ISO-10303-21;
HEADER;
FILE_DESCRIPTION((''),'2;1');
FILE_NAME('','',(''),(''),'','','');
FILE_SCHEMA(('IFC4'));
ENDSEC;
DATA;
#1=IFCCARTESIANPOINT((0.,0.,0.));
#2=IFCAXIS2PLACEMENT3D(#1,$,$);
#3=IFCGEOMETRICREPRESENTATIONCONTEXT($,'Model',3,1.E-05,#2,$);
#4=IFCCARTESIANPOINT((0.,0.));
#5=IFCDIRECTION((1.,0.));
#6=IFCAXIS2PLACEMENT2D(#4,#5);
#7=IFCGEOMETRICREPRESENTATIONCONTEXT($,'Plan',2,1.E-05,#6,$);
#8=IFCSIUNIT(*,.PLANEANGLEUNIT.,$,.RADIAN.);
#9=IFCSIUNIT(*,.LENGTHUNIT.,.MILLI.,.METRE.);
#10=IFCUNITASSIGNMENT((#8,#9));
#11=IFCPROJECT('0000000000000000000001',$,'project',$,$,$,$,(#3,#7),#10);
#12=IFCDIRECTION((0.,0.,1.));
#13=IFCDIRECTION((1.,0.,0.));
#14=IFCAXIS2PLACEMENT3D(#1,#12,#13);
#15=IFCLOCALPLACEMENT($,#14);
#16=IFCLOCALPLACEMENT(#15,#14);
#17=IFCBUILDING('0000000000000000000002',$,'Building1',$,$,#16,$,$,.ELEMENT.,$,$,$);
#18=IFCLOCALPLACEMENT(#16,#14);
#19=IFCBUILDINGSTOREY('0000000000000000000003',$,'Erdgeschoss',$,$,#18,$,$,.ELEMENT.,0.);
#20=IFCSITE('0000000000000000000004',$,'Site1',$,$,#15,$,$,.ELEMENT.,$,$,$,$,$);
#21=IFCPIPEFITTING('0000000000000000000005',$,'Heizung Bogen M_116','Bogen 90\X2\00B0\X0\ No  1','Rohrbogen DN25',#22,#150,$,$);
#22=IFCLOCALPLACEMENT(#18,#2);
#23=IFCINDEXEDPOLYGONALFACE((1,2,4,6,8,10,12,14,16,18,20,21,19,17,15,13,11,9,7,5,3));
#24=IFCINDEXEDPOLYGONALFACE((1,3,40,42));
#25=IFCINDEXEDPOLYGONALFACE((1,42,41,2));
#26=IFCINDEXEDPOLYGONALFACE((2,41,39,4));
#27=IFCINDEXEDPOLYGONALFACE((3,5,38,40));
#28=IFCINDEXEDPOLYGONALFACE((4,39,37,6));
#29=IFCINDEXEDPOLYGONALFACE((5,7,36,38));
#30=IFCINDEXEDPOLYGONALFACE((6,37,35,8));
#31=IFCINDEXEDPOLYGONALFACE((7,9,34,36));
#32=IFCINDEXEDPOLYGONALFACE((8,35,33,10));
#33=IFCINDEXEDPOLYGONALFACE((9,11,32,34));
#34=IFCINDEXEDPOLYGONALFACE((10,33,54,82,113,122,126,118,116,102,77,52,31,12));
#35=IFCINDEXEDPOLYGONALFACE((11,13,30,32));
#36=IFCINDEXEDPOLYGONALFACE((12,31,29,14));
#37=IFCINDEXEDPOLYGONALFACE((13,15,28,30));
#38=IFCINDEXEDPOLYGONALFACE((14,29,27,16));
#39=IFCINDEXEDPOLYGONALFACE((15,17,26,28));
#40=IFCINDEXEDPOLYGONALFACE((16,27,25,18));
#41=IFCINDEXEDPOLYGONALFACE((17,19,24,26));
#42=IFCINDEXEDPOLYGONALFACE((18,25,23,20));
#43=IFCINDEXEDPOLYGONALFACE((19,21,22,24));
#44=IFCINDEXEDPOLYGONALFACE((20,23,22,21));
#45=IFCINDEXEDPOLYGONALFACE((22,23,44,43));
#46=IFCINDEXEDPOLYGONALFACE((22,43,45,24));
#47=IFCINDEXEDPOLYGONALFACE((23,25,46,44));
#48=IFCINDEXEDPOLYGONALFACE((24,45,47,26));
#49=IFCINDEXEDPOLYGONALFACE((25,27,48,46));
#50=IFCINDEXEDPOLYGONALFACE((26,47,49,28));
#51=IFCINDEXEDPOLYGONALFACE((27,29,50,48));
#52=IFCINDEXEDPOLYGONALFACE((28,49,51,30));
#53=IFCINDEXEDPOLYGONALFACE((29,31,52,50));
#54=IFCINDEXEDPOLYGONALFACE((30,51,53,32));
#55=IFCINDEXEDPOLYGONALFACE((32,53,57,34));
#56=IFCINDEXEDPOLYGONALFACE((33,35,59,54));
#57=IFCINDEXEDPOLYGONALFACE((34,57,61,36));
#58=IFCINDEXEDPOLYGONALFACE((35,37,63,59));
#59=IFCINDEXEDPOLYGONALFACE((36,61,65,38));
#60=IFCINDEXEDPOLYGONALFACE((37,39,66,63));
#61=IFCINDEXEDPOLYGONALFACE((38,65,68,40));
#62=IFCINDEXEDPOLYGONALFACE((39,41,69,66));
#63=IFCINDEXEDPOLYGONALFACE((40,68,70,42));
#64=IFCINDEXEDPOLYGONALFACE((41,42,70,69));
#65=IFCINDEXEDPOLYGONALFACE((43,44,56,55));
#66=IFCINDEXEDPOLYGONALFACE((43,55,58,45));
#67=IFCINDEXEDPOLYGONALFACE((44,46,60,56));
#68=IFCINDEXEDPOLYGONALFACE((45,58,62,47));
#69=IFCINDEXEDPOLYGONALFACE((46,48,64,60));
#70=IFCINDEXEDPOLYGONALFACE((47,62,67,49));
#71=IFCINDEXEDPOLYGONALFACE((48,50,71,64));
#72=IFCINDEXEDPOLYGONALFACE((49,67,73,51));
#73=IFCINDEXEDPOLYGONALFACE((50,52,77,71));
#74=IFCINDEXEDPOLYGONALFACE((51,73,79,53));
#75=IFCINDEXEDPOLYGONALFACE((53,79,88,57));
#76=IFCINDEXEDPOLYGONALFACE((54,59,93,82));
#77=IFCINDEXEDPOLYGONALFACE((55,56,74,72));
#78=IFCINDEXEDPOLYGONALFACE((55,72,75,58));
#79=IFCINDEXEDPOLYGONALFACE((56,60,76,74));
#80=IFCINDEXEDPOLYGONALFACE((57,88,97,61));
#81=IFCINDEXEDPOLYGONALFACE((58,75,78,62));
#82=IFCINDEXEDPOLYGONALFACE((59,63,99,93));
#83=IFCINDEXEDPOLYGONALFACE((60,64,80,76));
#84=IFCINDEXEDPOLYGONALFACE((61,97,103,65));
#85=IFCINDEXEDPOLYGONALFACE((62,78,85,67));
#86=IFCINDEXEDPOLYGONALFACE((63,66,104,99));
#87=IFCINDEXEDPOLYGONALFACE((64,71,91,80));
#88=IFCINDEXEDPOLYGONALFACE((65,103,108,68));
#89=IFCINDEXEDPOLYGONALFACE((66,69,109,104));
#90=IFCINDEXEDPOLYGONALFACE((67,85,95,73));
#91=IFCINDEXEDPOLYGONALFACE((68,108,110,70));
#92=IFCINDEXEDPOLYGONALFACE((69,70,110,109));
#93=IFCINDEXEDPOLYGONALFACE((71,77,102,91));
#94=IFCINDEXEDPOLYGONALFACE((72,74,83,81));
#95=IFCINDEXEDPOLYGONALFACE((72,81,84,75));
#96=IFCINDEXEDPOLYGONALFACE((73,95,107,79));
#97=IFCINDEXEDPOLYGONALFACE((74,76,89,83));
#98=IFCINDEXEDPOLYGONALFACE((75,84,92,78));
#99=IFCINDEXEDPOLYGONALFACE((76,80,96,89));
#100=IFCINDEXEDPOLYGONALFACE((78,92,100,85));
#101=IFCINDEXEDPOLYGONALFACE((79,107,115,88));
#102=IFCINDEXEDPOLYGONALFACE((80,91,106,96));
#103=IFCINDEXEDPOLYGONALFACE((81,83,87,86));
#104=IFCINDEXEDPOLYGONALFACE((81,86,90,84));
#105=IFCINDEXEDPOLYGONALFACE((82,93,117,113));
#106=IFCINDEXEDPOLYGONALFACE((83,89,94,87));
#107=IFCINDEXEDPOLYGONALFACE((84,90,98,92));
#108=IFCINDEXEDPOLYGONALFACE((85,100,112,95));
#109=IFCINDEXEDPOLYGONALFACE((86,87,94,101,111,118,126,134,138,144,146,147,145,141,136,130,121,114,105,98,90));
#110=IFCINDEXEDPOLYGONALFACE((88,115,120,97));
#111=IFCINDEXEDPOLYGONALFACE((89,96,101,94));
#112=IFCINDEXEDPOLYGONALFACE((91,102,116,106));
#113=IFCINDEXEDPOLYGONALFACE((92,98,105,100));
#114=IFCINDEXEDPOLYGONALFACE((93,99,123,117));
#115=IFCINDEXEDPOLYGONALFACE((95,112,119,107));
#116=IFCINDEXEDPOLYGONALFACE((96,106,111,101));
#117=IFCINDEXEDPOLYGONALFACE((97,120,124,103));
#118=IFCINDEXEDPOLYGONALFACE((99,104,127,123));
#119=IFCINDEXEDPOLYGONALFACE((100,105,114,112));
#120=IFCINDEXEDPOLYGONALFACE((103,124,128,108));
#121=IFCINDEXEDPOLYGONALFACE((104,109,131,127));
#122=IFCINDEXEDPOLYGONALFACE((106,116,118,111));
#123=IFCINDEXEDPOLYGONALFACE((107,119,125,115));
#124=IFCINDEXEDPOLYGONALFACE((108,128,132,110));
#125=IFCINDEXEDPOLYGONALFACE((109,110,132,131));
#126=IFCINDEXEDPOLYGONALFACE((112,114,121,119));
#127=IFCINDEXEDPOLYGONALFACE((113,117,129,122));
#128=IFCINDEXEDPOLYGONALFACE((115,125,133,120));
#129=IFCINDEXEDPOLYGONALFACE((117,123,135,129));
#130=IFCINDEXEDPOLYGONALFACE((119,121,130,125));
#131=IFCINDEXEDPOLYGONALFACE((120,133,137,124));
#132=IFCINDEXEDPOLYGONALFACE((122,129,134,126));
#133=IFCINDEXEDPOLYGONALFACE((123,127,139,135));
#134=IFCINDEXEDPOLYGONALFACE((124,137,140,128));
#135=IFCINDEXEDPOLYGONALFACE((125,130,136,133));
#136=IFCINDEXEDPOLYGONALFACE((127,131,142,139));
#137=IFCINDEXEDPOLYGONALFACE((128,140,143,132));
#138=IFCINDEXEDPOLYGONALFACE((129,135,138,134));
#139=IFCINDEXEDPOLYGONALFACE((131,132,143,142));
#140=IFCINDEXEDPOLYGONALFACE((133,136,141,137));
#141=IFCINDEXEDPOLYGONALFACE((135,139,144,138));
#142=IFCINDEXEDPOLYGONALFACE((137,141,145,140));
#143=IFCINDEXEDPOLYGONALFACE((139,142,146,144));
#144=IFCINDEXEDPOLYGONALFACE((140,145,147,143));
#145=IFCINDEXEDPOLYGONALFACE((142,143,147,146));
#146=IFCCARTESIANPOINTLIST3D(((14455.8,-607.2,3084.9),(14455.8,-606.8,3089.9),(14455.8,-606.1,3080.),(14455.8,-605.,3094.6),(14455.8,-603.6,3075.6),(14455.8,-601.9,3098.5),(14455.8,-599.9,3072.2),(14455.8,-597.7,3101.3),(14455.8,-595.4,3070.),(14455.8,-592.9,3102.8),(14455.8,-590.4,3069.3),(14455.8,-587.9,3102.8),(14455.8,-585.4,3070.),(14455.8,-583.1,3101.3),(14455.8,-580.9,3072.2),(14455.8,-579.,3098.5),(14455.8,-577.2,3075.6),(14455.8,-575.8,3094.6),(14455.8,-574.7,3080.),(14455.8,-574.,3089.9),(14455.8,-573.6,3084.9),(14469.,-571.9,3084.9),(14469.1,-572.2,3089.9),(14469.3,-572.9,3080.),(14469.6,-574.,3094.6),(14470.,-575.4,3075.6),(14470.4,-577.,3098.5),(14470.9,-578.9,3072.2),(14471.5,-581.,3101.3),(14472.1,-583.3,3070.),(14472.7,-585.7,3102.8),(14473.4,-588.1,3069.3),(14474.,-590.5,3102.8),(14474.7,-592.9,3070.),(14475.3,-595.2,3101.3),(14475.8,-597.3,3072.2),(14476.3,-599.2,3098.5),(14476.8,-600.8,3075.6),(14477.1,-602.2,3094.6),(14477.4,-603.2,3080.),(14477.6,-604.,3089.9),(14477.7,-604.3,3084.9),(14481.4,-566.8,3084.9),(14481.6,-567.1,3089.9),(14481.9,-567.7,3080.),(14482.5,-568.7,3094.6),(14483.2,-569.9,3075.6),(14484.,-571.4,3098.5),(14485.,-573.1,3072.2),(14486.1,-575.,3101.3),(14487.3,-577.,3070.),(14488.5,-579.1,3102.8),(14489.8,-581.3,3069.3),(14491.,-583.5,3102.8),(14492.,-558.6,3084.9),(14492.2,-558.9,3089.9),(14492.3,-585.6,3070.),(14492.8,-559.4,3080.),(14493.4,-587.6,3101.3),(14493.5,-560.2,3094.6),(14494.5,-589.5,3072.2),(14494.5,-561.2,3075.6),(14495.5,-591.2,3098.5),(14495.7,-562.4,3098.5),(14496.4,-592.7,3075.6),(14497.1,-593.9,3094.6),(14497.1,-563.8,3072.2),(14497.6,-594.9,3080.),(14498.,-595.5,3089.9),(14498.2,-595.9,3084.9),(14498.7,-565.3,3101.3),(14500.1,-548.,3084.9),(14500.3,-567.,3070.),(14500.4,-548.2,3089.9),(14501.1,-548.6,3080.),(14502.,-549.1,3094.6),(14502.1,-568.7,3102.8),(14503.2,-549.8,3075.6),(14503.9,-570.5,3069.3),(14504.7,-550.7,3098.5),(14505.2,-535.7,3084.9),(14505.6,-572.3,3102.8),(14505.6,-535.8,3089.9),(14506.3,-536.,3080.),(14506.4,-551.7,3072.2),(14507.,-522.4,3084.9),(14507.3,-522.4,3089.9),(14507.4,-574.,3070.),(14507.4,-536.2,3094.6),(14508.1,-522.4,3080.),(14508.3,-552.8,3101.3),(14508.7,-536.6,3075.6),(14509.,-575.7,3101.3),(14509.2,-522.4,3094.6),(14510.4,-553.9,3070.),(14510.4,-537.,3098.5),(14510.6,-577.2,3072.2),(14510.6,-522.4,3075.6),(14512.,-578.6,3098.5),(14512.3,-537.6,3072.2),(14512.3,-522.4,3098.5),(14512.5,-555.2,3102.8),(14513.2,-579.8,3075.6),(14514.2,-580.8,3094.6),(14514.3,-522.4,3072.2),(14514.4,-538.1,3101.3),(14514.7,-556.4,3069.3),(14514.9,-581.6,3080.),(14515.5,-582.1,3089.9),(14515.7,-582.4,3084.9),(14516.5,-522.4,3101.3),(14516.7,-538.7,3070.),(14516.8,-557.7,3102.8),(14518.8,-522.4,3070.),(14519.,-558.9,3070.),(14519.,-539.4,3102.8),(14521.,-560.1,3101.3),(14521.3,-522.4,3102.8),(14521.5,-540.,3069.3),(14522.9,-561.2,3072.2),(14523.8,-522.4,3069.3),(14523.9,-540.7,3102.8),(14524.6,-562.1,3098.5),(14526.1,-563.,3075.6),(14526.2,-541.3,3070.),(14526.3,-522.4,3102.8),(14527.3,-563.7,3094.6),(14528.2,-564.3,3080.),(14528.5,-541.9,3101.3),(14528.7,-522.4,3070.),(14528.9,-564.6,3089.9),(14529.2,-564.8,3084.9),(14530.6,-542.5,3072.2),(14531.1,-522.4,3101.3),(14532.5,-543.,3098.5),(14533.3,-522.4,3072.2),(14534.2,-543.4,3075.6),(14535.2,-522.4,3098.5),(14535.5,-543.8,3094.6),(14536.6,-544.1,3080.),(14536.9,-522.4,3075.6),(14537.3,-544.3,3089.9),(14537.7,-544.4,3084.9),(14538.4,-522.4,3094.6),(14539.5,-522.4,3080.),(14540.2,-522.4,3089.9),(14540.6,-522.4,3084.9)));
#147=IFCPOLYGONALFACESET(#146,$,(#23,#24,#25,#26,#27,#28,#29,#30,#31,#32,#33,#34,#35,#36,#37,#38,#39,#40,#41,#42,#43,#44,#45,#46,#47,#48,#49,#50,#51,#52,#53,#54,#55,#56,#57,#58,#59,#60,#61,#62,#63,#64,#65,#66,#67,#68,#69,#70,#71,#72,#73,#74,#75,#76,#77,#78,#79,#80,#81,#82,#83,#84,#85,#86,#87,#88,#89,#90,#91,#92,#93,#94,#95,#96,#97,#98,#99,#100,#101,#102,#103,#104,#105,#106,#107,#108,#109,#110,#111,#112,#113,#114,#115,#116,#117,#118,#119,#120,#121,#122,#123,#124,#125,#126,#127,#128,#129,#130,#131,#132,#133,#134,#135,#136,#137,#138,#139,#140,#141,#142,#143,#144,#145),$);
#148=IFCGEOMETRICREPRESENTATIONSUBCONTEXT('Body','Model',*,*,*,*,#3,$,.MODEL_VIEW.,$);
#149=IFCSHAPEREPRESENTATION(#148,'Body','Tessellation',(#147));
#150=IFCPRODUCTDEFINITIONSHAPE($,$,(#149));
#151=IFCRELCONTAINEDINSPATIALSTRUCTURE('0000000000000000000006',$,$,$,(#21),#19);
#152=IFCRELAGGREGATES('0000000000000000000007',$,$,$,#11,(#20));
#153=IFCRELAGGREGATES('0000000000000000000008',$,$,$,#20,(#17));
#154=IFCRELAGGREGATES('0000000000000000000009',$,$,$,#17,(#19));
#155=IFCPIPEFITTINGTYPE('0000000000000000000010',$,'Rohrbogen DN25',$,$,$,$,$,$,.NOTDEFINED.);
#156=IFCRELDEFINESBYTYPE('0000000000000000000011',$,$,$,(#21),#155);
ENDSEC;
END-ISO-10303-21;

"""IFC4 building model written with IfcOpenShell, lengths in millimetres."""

from ifc_helpers import new_model, entity, si_unit, frame, origin, origin_with_axes, origin_2d_with_axis, place, context, subcontext, project, spatial, source, transform, mapped, type_object, element, save


model = new_model("IFC4")

# Units and contexts
model_context = context("Model", 3, precision=1e-05, world=origin())
plan_context = context("Plan", 2, precision=1e-05, world=origin_2d_with_axis())
body_context = subcontext(model_context, "Body", "Model", "MODEL_VIEW")
ifc_project = project(units=[si_unit("PLANEANGLEUNIT", "RADIAN"), si_unit("LENGTHUNIT", "METRE", prefix="MILLI")], contexts=[model_context, plan_context])

# Site, building, storey
site_placement = place(None, origin_with_axes())
site = spatial("IfcSite", under=ifc_project, at=site_placement, Name="Site1", CompositionType="ELEMENT")
building_placement = place(site_placement, origin_with_axes())
building = spatial("IfcBuilding", under=site, at=building_placement, Name="Building1", CompositionType="ELEMENT")
storey_placement = place(building_placement, origin_with_axes())
storey = spatial("IfcBuildingStorey", under=building, at=storey_placement, Name="Erdgeschoss", CompositionType="ELEMENT", Elevation=0.0)

# Pipe fitting
pipe_fitting_type = type_object("IfcPipeFittingType", Name="Rohrbogen DN25", PredefinedType="NOTDEFINED")
shared_shape_1 = source(origin_with_axes(), body_context, "Body", "SolidModel", [
    entity("IfcRevolvedAreaSolid", entity("IfcCircleProfileDef", "AREA", None, entity("IfcAxis2Placement2D", entity("IfcCartesianPoint", [0.0, 0.0]), entity("IfcDirection", [1.0, 0.0])), 16.9), entity("IfcAxis2Placement3D", entity("IfcCartesianPoint", [-42.4, 25.6, 0.0]), entity("IfcDirection", [1.0, 0.0, 0.0]), entity("IfcDirection", [0.0, 0.0, 1.0])), entity("IfcAxis1Placement", entity("IfcCartesianPoint", [0.0, 68.0, 0.0]), entity("IfcDirection", [-1.0, 0.0, 0.0])), 1.570796),
])
pipe_fitting_1_placement = place(storey_placement, frame((14498.2, -564.8, 3086.1), z_axis=(0.0, 0.0, 1.0), x_axis=(1.0, 0.0, 0.0)))
element("IfcPipeFitting", 1, at=pipe_fitting_1_placement, inside=storey, type_object=pipe_fitting_type, Name="Heizung Bogen M_116", Description="Bogen 90° No  1", ObjectType="Rohrbogen DN25", context=body_context, shape_type="MappedRepresentation", body=[
    mapped(shared_shape_1, transform((0.0, 0.0, 0.0), x_axis=(1.0, 0.0, 0.0), y_axis=(0.0, -1.0, 0.0), z_axis=(0.0, 0.0, -1.0), scale=1.0)),
])

save(model, "model.ifc")
